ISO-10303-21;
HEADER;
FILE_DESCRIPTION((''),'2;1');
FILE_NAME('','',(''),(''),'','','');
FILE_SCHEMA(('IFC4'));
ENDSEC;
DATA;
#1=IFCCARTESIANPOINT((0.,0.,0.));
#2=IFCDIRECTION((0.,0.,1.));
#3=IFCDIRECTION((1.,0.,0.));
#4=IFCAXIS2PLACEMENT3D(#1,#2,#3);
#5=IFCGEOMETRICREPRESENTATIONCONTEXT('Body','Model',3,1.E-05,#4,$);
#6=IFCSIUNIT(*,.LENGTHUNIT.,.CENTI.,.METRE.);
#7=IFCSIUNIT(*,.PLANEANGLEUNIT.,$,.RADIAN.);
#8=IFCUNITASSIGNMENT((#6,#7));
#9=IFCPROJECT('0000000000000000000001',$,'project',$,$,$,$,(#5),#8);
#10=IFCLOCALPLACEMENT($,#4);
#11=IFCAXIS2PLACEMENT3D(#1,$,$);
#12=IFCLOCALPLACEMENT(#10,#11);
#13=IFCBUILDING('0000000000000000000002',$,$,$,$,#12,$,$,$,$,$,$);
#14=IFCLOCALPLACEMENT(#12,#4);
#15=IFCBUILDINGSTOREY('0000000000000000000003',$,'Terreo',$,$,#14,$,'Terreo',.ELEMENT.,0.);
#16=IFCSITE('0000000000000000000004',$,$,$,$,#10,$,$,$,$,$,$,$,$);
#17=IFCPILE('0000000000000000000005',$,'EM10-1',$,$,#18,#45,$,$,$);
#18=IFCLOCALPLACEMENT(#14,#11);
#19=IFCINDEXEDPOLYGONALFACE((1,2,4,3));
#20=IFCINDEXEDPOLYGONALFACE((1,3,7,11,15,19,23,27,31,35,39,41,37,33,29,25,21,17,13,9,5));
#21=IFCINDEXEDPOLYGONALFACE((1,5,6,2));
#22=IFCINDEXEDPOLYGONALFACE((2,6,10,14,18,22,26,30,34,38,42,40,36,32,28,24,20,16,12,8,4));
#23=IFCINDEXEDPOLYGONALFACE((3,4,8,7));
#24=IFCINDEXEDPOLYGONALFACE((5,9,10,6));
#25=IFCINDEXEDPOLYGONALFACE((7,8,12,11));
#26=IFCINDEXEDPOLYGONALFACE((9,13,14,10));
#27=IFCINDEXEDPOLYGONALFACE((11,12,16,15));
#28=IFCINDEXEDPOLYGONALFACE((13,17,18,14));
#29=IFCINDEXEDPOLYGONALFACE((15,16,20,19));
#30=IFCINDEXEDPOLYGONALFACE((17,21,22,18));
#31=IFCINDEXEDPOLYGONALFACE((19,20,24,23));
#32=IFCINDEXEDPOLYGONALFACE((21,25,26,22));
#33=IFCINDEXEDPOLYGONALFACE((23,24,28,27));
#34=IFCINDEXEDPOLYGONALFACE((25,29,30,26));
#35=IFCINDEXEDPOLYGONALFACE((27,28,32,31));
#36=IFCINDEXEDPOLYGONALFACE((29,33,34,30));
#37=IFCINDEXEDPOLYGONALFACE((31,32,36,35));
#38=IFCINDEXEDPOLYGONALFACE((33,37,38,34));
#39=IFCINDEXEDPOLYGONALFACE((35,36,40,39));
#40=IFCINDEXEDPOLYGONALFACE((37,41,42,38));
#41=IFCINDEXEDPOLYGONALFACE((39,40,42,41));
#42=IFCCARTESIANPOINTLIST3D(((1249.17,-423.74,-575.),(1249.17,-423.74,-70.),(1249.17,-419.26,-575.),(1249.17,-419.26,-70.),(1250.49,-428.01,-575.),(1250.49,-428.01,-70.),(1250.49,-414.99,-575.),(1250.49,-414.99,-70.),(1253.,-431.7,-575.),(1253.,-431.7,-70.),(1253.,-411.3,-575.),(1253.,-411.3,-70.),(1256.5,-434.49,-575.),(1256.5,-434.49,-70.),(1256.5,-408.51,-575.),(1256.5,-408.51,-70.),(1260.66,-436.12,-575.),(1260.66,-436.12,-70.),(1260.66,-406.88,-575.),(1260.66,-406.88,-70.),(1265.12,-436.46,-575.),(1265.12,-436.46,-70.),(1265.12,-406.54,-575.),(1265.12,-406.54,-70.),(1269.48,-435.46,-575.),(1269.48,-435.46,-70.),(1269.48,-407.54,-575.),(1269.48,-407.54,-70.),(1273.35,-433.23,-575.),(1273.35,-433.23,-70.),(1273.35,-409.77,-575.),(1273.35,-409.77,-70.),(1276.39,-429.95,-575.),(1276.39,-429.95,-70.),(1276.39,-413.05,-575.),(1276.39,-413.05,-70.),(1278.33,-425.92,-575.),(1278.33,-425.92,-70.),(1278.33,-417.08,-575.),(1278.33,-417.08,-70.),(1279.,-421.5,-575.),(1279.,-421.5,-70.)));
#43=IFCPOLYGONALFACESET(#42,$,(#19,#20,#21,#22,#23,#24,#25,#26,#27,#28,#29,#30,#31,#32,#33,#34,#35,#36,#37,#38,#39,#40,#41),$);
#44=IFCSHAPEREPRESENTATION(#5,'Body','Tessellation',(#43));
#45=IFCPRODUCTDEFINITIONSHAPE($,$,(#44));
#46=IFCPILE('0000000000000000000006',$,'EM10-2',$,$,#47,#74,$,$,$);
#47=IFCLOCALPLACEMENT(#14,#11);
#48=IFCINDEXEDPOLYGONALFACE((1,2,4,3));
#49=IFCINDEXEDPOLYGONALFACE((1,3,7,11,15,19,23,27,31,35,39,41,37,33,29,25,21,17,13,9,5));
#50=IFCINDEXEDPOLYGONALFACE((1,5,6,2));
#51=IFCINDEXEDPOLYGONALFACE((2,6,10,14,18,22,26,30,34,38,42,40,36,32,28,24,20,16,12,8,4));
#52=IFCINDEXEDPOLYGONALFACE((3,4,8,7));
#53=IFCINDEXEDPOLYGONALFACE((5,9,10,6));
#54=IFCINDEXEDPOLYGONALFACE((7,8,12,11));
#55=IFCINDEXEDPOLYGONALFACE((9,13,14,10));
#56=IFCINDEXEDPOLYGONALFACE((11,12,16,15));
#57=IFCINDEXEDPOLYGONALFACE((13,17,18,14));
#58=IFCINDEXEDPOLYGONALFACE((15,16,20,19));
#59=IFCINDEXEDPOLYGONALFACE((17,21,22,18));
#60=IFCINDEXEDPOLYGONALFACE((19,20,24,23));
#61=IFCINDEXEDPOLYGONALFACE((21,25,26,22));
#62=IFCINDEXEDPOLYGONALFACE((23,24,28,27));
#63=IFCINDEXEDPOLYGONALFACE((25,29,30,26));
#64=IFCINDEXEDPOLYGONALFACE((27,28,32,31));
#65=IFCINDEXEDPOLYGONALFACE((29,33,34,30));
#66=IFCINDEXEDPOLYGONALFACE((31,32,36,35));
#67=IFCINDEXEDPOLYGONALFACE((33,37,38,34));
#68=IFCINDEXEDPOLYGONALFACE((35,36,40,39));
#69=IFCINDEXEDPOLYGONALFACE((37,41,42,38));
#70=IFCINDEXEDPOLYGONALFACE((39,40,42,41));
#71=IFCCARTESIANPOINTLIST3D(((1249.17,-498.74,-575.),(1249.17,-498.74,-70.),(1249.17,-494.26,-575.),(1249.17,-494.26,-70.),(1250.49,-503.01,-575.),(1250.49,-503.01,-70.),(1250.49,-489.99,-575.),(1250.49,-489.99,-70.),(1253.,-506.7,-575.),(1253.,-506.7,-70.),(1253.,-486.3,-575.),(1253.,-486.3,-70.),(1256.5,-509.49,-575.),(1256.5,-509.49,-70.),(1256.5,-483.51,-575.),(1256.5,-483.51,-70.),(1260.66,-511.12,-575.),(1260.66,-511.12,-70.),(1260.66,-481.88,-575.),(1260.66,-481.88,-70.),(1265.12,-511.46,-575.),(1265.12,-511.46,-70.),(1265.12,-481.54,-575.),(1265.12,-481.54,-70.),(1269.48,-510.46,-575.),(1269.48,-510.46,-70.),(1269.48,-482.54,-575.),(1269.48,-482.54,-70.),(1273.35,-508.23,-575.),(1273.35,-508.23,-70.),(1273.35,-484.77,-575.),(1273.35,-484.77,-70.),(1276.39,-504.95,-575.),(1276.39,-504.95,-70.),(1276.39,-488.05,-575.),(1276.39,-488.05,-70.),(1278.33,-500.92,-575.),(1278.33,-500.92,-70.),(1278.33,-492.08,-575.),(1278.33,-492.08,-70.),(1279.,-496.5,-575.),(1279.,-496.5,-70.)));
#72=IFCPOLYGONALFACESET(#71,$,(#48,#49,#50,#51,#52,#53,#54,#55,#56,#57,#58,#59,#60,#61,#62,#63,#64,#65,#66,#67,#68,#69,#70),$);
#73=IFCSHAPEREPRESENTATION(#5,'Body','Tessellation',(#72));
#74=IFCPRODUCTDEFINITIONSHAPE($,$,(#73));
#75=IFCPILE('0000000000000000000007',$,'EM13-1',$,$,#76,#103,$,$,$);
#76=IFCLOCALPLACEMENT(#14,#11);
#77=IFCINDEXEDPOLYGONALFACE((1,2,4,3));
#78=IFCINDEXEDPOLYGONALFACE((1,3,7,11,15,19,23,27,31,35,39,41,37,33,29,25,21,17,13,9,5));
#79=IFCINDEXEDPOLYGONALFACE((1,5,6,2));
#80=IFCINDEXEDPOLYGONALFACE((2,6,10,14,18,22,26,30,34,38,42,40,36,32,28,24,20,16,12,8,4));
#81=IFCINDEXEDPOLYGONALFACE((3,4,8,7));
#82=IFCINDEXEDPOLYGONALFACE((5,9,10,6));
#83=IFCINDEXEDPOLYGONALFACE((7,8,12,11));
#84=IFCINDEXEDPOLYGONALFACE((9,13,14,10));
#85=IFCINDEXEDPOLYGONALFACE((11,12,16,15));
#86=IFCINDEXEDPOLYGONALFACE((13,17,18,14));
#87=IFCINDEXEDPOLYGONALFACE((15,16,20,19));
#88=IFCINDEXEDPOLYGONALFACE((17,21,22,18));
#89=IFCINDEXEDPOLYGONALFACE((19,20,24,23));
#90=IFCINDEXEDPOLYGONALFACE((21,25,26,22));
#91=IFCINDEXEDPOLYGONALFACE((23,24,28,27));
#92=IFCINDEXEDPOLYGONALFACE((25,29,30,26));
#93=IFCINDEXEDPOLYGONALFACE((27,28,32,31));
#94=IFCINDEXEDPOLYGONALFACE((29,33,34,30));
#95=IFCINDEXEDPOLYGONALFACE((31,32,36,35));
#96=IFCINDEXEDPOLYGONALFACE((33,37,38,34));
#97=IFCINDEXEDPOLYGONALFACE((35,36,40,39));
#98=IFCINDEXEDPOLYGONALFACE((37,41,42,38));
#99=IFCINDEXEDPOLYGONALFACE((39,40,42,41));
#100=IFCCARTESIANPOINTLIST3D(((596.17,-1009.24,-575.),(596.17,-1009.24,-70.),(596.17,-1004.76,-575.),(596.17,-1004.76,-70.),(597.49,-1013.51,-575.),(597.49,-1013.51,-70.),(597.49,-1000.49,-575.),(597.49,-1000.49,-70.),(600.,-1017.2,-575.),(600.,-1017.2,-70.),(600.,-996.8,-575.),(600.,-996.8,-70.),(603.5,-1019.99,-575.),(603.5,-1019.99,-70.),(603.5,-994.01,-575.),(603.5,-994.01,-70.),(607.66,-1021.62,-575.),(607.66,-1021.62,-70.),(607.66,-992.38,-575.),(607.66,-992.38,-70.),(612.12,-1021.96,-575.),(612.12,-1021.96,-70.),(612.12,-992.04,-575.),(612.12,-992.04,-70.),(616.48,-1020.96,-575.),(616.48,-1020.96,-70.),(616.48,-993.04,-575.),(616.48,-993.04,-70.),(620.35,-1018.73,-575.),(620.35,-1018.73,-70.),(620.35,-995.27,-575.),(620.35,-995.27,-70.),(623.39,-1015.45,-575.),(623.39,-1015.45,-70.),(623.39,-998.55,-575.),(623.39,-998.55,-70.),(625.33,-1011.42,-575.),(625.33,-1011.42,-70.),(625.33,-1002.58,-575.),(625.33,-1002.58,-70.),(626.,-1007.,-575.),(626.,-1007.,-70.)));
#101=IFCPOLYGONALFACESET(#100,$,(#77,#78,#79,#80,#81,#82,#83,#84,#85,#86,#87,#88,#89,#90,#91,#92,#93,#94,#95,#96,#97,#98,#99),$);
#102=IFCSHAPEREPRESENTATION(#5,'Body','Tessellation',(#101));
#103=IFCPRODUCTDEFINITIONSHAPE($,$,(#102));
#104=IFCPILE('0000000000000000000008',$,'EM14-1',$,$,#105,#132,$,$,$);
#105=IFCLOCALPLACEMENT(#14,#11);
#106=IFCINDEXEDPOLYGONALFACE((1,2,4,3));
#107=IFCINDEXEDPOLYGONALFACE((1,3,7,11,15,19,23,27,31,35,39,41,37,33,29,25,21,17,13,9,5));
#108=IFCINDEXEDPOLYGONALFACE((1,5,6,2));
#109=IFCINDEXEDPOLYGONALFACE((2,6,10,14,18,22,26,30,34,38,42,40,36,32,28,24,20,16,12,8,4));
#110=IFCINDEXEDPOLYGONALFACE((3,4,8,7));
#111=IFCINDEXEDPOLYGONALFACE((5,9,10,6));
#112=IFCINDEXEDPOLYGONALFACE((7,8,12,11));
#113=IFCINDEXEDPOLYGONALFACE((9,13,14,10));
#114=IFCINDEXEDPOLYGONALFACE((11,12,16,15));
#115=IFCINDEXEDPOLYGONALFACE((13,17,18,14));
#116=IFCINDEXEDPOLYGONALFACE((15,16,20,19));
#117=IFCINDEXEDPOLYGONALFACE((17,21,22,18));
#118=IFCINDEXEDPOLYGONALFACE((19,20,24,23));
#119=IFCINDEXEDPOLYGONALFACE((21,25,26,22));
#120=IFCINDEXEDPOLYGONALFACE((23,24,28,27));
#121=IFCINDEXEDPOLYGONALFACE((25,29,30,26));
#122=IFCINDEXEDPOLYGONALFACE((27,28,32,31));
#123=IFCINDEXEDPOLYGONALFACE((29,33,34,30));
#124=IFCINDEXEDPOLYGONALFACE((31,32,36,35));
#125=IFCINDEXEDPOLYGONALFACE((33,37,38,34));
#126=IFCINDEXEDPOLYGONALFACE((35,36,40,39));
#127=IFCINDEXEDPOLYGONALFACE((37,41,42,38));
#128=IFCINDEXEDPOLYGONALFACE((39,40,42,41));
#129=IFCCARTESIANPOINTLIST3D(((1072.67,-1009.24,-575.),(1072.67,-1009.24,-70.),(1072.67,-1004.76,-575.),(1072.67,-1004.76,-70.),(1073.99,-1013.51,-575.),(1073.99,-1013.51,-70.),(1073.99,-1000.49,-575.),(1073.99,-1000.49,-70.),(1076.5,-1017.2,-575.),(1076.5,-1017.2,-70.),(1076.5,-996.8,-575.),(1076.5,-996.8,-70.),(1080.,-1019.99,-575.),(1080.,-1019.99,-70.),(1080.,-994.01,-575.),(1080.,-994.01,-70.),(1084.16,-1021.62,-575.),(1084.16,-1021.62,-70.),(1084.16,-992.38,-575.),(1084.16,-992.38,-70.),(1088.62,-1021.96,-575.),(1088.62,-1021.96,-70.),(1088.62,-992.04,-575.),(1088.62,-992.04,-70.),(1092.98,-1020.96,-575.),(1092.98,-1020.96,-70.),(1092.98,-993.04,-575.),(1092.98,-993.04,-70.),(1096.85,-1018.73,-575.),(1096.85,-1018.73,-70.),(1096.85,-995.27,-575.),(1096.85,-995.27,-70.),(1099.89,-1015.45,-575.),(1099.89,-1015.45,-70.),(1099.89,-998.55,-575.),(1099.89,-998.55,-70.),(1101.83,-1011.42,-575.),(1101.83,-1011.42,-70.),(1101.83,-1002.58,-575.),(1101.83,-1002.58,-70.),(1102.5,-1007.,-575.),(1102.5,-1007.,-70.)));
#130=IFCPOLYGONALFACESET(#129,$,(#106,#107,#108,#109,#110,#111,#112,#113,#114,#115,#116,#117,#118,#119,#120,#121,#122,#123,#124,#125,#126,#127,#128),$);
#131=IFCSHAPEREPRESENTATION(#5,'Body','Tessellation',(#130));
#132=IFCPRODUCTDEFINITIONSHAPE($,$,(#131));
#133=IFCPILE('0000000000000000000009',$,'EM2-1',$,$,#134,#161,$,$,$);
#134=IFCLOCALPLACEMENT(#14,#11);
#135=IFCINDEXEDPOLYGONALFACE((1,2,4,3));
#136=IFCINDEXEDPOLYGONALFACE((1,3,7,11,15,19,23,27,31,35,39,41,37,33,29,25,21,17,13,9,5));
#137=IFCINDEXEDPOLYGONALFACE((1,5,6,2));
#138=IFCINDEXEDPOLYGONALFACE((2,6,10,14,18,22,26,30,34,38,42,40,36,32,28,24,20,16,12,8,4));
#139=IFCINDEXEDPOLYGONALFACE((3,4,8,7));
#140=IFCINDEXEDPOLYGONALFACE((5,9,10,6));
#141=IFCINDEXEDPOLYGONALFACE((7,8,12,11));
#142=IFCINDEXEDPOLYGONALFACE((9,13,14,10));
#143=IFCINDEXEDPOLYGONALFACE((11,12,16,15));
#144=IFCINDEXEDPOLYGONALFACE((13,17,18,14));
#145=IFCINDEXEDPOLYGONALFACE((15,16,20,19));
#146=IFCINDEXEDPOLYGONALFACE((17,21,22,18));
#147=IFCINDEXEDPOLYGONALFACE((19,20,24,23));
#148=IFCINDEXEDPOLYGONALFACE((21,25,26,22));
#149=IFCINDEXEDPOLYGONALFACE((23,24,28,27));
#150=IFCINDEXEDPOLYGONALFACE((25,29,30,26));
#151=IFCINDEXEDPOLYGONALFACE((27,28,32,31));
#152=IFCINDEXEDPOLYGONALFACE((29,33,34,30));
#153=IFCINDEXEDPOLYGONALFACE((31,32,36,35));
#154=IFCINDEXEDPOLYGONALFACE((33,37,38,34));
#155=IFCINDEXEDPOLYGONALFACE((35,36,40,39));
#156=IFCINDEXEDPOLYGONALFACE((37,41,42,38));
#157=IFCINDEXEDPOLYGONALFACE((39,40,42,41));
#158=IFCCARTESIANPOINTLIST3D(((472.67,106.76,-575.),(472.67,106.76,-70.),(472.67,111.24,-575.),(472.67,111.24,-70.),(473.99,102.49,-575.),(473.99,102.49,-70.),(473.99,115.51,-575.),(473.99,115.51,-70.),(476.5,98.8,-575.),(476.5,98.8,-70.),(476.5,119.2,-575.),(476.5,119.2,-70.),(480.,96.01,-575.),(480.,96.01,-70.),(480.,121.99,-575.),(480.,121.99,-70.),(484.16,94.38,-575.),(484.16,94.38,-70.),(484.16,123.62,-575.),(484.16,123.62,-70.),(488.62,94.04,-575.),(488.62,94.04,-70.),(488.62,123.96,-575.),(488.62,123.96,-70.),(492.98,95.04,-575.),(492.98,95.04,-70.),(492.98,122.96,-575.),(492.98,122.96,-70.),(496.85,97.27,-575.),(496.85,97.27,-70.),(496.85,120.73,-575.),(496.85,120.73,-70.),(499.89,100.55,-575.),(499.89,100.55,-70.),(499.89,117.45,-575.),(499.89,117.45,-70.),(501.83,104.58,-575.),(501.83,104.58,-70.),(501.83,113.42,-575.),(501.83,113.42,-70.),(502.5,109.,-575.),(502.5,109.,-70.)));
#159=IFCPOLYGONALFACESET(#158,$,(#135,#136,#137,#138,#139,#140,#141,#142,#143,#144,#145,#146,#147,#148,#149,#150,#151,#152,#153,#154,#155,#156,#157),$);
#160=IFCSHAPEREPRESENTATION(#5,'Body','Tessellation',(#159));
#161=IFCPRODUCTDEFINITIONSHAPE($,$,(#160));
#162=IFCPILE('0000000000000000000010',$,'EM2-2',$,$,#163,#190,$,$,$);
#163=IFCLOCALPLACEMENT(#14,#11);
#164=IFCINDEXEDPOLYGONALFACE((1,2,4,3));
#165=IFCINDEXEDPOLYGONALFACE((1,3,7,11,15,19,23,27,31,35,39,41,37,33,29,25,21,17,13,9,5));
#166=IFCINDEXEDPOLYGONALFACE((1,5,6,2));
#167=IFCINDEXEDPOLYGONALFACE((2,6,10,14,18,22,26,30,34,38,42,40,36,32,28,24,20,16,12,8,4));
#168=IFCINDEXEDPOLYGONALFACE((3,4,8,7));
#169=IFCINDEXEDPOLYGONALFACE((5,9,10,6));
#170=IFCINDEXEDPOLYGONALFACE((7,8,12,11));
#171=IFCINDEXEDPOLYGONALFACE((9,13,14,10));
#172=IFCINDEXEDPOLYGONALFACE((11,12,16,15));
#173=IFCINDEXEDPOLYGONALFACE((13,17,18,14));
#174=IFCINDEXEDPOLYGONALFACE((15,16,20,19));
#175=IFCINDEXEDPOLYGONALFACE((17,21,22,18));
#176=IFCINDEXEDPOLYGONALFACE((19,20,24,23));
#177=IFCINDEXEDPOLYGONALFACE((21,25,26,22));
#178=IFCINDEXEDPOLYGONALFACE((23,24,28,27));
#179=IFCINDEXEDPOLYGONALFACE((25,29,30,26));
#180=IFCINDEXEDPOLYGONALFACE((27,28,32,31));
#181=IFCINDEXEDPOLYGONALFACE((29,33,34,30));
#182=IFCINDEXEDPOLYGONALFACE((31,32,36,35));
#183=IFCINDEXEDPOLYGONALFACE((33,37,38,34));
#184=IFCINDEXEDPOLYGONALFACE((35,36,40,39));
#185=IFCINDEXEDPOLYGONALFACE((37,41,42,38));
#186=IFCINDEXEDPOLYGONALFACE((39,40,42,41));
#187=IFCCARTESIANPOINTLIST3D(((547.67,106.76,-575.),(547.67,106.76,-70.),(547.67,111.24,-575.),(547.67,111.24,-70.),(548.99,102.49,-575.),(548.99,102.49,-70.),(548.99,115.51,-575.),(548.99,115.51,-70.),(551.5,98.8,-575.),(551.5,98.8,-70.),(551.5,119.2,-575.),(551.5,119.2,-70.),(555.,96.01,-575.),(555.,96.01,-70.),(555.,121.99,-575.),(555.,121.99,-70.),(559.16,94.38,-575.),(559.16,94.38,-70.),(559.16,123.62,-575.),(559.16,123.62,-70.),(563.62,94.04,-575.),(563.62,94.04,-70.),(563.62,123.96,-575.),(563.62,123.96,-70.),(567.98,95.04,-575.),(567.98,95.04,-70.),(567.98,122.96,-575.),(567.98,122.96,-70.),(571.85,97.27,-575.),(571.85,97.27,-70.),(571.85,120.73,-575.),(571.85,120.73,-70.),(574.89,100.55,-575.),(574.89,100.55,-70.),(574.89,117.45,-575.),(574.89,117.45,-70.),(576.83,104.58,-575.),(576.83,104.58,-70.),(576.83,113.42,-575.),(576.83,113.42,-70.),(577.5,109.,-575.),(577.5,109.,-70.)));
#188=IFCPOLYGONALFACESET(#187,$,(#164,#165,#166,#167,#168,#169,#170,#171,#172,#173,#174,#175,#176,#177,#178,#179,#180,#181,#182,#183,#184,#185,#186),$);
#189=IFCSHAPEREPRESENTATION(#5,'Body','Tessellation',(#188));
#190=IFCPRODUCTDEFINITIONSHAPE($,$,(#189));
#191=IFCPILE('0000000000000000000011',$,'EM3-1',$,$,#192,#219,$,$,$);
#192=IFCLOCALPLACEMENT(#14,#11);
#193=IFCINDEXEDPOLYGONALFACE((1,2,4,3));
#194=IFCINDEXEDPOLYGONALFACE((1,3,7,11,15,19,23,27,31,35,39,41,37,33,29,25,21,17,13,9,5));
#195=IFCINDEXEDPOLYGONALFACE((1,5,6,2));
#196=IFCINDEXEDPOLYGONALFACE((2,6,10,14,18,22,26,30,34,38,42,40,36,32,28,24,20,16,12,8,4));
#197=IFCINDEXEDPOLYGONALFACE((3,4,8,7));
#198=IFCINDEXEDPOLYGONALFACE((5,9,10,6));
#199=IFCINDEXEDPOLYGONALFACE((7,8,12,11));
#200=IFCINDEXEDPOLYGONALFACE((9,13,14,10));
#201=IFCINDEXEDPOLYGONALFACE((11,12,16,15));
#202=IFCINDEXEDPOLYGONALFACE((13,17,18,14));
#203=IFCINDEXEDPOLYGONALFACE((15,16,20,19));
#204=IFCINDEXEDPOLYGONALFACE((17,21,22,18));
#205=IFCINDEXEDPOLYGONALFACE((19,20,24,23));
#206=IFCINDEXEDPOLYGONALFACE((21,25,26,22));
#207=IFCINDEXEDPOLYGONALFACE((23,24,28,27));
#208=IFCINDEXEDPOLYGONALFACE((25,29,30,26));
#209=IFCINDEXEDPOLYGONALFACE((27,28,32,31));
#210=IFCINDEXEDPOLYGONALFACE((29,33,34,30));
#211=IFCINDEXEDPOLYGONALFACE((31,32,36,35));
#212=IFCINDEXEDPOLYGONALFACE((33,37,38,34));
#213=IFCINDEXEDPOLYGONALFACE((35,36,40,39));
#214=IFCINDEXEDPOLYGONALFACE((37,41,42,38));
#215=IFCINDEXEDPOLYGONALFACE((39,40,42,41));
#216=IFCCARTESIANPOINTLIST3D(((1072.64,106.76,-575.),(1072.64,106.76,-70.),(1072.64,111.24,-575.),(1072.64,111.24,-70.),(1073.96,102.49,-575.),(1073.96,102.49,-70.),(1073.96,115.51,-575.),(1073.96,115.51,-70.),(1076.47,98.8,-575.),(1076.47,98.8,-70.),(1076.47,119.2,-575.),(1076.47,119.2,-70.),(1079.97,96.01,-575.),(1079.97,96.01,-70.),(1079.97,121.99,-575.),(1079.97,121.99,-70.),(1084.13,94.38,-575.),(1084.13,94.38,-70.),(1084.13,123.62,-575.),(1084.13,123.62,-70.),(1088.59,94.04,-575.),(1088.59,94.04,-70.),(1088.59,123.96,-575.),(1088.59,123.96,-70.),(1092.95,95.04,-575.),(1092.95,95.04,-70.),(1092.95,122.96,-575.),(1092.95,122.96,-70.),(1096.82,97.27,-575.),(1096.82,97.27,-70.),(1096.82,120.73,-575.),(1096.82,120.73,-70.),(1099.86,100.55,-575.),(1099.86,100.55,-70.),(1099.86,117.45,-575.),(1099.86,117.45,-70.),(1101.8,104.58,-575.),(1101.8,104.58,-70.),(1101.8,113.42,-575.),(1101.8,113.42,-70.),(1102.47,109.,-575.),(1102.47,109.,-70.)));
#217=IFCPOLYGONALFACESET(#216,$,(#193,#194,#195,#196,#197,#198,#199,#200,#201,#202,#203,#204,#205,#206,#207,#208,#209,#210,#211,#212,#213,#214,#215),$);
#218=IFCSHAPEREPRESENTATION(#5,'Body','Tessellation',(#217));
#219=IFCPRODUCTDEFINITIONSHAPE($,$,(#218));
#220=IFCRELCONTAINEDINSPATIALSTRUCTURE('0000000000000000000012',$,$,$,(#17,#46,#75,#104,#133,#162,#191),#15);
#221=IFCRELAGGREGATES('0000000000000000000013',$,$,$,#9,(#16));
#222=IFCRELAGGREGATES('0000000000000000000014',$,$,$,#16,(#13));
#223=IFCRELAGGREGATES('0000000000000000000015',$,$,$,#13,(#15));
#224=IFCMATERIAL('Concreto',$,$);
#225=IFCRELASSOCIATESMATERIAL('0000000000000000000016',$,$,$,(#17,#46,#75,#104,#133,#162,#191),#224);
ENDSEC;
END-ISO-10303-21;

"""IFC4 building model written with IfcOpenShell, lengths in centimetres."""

from ifc_helpers import new_model, si_unit, frame, origin, origin_with_axes, origin_2d_with_axis, place, context, project, spatial, circle, extrude, material, element, save


model = new_model("IFC4")

# Units and contexts
model_context = context("Model", 3, precision=1e-05, world=origin_with_axes(), identifier="Body")
ifc_project = project(units=[si_unit("LENGTHUNIT", "METRE", prefix="CENTI"), si_unit("PLANEANGLEUNIT", "RADIAN")], contexts=[model_context])

# Site, building, storey
site_placement = place(None, origin_with_axes())
site = spatial("IfcSite", under=ifc_project, at=site_placement)
building_placement = place(site_placement, origin())
building = spatial("IfcBuilding", under=site, at=building_placement)
storey_placement = place(building_placement, origin_with_axes())
storey = spatial("IfcBuildingStorey", under=building, at=storey_placement, Name="Terreo", LongName="Terreo", CompositionType="ELEMENT", Elevation=0.0)

# Piles
ifc_material = material(Name="Concreto")
for number, where, z_axis, x_axis, name in (
    (1, (1264.0, -421.5, -70.0), (0.0, 0.0, 1.0), (1.0, 0.0, 0.0), "EM10-1"),
    (2, (1264.0, -496.5, -70.0), (0.0, 0.0, 1.0), (1.0, 0.0, 0.0), "EM10-2"),
    (3, (611.0, -1007.0, -70.0), (0.0, 0.0, 1.0), (1.0, 0.0, 0.0), "EM13-1"),
    (4, (1087.5, -1007.0, -70.0), (0.0, 0.0, 1.0), (1.0, 0.0, 0.0), "EM14-1"),
    (5, (487.5, 109.0, -70.0), (0.0, 0.0, 1.0), (1.0, 0.0, 0.0), "EM2-1"),
    (6, (562.5, 109.0, -70.0), (0.0, 0.0, 1.0), (1.0, 0.0, 0.0), "EM2-2"),
    (7, (1087.47, 109.0, -70.0), (0.0, 0.0, 1.0), (1.0, 0.0, 0.0), "EM3-1"),
):
    element("IfcPile", number, at=place(storey_placement, frame(where, z_axis=z_axis, x_axis=x_axis)), inside=storey, material=ifc_material, Name=name, context=model_context, shape_type="SweptSolid", body=[
        extrude(circle(Radius=15.0, at=origin_2d_with_axis()), frame((0.0, 0.0, -505.0), z_axis=(0.0, 0.0, 1.0), x_axis=(1.0, 0.0, 0.0)), (0.0, 0.0, 1.0), 505.0),
    ])

save(model, "model.ifc")
